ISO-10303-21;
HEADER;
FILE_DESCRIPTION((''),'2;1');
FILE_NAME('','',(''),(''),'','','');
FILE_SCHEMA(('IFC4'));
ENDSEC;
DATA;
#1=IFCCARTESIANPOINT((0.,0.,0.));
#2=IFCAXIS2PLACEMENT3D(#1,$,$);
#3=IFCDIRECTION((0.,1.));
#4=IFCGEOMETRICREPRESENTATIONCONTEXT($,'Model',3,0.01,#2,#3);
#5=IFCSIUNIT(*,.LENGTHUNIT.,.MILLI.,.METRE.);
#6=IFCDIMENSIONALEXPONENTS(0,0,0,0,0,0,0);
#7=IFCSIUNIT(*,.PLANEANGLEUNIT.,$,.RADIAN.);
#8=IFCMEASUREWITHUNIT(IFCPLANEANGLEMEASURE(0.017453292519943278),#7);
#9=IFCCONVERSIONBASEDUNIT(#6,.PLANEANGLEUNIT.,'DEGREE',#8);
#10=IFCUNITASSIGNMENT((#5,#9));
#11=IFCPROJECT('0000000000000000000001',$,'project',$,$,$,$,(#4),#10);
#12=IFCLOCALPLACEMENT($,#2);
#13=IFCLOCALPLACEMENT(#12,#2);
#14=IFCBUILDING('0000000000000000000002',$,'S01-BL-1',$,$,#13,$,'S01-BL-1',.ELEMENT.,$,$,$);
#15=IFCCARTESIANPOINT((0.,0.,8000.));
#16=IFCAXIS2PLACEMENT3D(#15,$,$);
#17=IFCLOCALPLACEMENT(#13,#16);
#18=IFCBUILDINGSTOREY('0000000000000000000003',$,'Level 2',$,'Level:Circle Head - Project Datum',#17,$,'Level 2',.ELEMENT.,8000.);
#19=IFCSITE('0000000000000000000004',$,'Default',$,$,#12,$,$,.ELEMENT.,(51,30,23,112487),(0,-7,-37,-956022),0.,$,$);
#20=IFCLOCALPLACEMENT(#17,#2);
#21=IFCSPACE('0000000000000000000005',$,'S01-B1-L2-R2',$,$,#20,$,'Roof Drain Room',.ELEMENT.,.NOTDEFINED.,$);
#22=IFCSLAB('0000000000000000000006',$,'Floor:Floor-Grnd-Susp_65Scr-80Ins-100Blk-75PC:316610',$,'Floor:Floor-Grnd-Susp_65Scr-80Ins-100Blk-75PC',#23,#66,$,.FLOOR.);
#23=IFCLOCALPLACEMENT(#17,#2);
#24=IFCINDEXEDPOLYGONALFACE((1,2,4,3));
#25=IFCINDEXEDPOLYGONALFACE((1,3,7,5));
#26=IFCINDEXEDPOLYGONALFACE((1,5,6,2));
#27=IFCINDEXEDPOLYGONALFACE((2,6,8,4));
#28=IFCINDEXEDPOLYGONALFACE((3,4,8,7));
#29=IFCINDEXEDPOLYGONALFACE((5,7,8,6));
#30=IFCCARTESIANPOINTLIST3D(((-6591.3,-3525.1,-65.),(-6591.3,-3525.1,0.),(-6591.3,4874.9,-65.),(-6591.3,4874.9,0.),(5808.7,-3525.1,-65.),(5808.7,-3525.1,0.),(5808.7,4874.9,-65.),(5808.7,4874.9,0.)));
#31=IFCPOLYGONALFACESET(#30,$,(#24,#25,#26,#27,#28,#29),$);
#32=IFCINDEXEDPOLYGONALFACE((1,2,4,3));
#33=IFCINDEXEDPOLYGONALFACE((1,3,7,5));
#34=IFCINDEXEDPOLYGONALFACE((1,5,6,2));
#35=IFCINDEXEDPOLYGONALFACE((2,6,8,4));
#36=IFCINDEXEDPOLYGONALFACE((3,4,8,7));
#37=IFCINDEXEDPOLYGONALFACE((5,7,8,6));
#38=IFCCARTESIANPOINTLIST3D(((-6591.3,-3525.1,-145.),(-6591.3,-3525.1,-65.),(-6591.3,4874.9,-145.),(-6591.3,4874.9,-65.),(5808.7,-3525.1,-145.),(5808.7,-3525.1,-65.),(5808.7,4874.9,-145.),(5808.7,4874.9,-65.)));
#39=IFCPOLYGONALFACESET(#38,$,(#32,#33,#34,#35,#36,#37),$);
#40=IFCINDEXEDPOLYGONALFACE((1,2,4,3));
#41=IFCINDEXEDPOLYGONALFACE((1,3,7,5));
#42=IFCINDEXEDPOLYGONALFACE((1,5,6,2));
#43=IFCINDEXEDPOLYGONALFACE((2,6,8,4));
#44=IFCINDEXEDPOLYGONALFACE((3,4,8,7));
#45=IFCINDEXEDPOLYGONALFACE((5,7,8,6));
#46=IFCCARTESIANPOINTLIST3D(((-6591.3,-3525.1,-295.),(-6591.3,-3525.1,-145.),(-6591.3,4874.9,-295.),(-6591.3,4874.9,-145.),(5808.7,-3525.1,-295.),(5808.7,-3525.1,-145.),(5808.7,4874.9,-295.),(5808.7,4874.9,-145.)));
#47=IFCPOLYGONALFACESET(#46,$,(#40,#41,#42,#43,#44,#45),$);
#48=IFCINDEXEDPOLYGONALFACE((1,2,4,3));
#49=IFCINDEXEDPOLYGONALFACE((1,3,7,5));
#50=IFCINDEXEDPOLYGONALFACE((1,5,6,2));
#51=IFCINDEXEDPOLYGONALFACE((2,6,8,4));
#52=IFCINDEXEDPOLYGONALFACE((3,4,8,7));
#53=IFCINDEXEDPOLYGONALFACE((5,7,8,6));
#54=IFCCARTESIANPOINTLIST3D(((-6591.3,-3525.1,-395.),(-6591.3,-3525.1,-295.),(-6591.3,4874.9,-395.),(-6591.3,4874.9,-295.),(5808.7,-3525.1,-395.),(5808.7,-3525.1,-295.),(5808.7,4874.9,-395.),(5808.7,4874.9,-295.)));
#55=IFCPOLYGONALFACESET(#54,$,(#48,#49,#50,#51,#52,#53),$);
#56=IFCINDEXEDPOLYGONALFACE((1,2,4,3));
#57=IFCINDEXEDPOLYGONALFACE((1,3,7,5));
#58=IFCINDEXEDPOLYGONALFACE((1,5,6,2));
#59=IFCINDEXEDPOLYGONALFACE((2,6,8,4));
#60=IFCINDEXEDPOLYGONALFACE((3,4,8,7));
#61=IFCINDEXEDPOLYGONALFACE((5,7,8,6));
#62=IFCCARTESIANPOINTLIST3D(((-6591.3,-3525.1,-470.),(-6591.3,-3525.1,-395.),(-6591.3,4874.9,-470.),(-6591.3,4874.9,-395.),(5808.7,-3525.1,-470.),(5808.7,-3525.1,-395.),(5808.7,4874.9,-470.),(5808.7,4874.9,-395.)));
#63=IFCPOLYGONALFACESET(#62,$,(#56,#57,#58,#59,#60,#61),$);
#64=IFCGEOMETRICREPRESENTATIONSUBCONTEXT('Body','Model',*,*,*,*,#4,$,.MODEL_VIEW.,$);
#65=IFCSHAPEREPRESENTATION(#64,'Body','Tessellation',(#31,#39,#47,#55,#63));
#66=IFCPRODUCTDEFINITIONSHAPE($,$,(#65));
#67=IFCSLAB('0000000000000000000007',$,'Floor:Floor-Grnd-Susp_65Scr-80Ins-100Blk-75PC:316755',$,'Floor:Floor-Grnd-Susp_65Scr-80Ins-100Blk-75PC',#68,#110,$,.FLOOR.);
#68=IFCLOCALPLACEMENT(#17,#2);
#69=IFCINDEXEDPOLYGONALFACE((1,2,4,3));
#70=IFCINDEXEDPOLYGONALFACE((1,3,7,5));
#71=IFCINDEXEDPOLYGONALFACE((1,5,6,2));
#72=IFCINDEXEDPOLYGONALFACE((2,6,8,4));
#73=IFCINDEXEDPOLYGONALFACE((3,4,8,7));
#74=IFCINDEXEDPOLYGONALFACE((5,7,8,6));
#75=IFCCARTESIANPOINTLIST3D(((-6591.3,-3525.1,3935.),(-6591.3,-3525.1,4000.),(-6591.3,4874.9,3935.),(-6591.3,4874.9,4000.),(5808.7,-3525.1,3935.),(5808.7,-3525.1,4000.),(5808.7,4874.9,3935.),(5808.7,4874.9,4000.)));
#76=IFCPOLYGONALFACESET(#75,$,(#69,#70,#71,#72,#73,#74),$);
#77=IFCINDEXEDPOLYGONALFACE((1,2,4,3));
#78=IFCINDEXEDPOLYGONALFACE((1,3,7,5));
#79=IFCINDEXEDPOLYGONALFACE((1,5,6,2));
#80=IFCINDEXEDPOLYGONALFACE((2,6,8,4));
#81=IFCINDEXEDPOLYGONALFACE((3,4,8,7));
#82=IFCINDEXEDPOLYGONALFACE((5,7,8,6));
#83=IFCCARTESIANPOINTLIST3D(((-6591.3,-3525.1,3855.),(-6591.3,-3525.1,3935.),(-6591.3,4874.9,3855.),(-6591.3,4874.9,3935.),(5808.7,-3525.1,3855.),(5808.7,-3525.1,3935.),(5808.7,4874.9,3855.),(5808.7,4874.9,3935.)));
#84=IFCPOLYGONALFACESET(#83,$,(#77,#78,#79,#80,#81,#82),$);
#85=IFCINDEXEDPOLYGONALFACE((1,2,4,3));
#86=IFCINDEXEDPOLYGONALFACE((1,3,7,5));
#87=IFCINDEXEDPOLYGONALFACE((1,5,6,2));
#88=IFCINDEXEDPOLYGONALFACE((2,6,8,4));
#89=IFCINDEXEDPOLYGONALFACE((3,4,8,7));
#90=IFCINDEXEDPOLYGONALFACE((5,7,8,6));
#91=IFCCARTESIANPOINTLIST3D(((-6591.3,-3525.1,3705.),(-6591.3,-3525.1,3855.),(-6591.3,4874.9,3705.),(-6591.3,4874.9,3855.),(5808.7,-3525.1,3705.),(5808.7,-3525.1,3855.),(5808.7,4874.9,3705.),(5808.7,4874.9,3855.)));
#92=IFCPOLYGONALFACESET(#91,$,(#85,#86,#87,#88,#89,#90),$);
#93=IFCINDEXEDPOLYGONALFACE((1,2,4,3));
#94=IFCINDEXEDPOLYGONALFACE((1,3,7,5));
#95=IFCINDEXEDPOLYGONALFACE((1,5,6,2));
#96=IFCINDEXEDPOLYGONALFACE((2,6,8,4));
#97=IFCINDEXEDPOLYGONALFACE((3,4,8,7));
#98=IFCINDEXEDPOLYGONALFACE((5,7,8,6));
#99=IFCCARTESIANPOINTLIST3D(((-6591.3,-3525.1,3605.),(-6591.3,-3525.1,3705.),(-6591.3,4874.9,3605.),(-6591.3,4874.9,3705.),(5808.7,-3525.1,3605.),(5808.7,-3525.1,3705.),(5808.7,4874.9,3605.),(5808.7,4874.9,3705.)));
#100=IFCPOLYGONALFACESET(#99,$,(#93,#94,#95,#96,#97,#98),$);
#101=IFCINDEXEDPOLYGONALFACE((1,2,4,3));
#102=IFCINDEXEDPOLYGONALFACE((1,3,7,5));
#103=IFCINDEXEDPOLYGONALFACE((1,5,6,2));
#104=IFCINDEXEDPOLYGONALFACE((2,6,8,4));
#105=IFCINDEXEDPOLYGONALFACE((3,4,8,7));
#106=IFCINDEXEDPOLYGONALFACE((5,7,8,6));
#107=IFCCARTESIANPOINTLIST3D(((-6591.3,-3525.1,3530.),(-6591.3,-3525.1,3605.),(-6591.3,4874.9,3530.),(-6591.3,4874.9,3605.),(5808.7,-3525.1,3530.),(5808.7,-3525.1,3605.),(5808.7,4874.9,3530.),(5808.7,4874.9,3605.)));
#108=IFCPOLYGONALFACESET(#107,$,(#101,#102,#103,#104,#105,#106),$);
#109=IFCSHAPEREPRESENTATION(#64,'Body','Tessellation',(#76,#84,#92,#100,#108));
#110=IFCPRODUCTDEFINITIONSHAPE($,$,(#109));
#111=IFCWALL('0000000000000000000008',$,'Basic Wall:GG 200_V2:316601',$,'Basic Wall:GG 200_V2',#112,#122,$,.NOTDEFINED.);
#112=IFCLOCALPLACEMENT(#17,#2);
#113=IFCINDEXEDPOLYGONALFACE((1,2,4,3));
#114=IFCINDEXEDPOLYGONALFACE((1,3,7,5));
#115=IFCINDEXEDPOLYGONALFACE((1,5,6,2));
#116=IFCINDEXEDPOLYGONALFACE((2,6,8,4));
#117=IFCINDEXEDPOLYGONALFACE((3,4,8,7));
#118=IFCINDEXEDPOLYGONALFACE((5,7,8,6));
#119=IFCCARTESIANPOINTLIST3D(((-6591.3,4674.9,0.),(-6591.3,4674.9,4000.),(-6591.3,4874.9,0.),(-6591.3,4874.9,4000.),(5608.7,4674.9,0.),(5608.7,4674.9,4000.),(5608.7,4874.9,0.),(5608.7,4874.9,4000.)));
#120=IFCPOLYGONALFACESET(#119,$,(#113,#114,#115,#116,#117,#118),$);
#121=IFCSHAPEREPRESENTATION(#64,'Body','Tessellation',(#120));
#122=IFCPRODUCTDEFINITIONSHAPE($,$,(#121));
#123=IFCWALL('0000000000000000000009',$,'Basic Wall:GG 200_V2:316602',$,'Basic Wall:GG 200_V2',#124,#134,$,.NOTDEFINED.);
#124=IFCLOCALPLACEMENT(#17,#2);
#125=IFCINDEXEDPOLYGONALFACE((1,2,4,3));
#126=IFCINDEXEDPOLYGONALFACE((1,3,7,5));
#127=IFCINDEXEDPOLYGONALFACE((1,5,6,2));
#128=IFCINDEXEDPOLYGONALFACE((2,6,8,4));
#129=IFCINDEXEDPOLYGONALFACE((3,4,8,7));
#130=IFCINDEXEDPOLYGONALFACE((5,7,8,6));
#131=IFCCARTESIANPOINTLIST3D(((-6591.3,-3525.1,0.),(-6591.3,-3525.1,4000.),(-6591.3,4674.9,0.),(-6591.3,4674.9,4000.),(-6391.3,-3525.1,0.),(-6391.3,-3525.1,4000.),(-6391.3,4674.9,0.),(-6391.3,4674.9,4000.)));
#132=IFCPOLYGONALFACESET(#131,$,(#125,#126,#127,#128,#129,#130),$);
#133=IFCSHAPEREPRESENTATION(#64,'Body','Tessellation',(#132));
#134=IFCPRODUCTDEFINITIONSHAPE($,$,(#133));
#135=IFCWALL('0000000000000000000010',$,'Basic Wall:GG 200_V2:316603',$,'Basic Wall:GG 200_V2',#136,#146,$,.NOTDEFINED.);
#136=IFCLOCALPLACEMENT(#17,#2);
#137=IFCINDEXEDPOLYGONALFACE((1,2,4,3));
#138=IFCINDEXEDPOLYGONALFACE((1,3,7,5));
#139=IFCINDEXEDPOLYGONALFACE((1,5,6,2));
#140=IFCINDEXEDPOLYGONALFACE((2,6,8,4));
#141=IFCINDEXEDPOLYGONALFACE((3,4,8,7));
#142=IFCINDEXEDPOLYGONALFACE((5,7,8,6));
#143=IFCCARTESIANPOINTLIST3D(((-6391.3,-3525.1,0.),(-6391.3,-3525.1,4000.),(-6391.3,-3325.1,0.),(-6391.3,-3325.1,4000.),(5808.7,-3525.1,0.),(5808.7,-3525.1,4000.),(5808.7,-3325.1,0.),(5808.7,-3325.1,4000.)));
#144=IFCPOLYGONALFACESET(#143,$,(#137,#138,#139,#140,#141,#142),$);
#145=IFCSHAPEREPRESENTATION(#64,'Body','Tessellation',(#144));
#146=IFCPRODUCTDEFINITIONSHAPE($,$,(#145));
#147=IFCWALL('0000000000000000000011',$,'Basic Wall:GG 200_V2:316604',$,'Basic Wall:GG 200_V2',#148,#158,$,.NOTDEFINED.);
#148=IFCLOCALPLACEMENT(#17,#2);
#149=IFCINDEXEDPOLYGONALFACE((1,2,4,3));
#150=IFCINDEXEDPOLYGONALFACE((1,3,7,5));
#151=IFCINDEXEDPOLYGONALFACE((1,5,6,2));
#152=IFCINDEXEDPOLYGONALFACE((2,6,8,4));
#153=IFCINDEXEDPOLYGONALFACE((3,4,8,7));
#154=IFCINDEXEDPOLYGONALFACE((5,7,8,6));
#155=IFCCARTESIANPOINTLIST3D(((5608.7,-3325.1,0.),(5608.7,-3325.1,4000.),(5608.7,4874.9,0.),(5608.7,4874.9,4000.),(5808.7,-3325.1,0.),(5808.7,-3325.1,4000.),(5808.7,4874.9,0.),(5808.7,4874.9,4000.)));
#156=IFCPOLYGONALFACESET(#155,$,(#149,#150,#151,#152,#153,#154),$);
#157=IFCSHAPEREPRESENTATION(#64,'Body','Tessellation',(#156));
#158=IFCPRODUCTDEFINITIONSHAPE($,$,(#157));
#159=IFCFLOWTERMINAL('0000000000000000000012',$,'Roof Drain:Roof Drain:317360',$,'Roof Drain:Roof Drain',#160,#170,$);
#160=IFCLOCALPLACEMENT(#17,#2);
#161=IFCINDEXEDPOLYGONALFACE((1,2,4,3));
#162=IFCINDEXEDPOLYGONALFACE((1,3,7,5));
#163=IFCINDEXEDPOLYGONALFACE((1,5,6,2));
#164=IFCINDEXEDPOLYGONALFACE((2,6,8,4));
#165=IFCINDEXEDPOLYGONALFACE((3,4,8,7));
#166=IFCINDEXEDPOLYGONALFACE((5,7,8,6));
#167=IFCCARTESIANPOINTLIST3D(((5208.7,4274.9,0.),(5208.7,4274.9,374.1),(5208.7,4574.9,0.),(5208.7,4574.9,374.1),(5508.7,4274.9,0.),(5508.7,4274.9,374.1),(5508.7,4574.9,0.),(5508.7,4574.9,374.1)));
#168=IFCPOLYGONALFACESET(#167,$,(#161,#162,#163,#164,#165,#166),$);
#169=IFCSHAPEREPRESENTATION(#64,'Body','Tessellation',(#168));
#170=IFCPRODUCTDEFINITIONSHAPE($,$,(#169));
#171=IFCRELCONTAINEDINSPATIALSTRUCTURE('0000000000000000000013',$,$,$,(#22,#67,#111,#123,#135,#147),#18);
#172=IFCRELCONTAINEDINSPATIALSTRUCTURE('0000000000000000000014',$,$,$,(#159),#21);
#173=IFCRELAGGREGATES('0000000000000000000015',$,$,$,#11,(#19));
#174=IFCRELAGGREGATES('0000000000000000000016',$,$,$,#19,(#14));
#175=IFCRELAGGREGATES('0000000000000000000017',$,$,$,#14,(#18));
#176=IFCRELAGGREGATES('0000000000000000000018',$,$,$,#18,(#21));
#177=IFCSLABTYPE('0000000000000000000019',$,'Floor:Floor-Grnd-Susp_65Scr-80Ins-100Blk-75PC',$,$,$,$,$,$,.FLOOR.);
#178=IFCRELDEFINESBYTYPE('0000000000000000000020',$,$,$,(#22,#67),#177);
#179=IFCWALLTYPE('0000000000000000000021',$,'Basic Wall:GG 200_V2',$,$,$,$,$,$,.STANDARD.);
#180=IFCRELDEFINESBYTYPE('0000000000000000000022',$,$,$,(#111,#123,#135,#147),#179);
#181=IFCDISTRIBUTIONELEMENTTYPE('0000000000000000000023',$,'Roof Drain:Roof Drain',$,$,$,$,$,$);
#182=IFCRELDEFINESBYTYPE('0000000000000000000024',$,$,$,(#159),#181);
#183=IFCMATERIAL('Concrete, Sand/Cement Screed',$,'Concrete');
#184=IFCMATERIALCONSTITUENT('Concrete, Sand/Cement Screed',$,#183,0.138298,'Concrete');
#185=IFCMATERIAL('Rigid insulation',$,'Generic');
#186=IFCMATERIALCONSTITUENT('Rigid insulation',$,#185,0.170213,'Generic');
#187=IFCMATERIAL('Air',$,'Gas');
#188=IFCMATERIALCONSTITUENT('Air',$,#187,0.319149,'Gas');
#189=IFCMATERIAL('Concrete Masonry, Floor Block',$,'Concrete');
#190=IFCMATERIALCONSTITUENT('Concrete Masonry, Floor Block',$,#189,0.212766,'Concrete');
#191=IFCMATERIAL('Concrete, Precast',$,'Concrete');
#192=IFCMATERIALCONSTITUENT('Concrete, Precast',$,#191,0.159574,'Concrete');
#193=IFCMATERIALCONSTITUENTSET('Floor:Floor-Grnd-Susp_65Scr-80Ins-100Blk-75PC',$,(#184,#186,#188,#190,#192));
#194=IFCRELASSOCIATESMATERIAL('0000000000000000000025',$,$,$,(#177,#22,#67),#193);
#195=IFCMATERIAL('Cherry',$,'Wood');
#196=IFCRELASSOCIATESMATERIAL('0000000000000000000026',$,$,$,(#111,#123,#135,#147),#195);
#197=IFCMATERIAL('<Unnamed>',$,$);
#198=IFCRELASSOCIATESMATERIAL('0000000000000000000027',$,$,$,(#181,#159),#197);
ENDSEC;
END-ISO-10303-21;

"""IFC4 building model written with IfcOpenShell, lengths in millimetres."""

from ifc_helpers import new_model, entity, si_unit, converted_unit, direction, frame, origin, place, context, subcontext, project, spatial, indexed_curve, outline, extrude, source, transform, mapped, material, constituent, constituent_set, type_object, type_shapes, element, save


model = new_model("IFC4")

# Units and contexts
model_context = context("Model", 3, precision=0.01, world=origin(), true_north=direction((0.0, 1.0)))
body_context = subcontext(model_context, "Body", "Model", "MODEL_VIEW")
ifc_project = project(units=[si_unit("LENGTHUNIT", "METRE", prefix="MILLI"), converted_unit("PLANEANGLEUNIT", "DEGREE", entity("IfcPlaneAngleMeasure", 0.017453292519943278), si_unit("PLANEANGLEUNIT", "RADIAN"), dimensions=[0, 0, 0, 0, 0, 0, 0])], contexts=[model_context])

# Site, building, storey
site_placement = place(None, origin())
site = spatial("IfcSite", under=ifc_project, at=site_placement, Name="Default", CompositionType="ELEMENT", RefLatitude=(51, 30, 23, 112487), RefLongitude=(0, -7, -37, -956022), RefElevation=0.0)
building_placement = place(site_placement, origin())
building = spatial("IfcBuilding", under=site, at=building_placement, Name="S01-BL-1", LongName="S01-BL-1", CompositionType="ELEMENT")
storey_placement = place(building_placement, frame((0.0, 0.0, 8000.0)))
storey = spatial("IfcBuildingStorey", under=building, at=storey_placement, Name="Level 2", ObjectType="Level:Circle Head - Project Datum", LongName="Level 2", CompositionType="ELEMENT", Elevation=8000.0)

# Slabs
ifc_material_1 = material(Name="Concrete, Sand/Cement Screed", Category="Concrete")
ifc_constituent_1 = constituent(ifc_material_1, Name="Concrete, Sand/Cement Screed", Category="Concrete", fraction=0.138298)
ifc_material_2 = material(Name="Rigid insulation", Category="Generic")
ifc_constituent_2 = constituent(ifc_material_2, Name="Rigid insulation", Category="Generic", fraction=0.170213)
ifc_material_3 = material(Name="Air", Category="Gas")
ifc_constituent_3 = constituent(ifc_material_3, Name="Air", Category="Gas", fraction=0.319149)
ifc_material_4 = material(Name="Concrete Masonry, Floor Block", Category="Concrete")
ifc_constituent_4 = constituent(ifc_material_4, Name="Concrete Masonry, Floor Block", Category="Concrete", fraction=0.212766)
ifc_material_5 = material(Name="Concrete, Precast", Category="Concrete")
ifc_constituent_5 = constituent(ifc_material_5, Name="Concrete, Precast", Category="Concrete", fraction=0.159574)
ifc_constituent_set = constituent_set(constituents=[ifc_constituent_1, ifc_constituent_2, ifc_constituent_3, ifc_constituent_4, ifc_constituent_5], Name="Floor:Floor-Grnd-Susp_65Scr-80Ins-100Blk-75PC")
slab_type = type_object("IfcSlabType", Name="Floor:Floor-Grnd-Susp_65Scr-80Ins-100Blk-75PC", PredefinedType="FLOOR", material=ifc_constituent_set)
slab_1_placement = place(storey_placement, origin())
element("IfcSlab", 1, at=slab_1_placement, inside=storey, type_object=slab_type, material=ifc_constituent_set, Name="Floor:Floor-Grnd-Susp_65Scr-80Ins-100Blk-75PC:316610", ObjectType="Floor:Floor-Grnd-Susp_65Scr-80Ins-100Blk-75PC", PredefinedType="FLOOR", context=body_context, shape_type="SweptSolid", body=[
    extrude(outline(indexed_curve([(-6200.0, -4200.0), (6200.0, -4200.0), (6200.0, 4200.0), (-6200.0, 4200.0), (-6200.0, -4200.0)], self_intersect=False)), frame((-391.3, 674.9, -65.0), z_axis=(0.0, 0.0, 1.0), x_axis=(-1.0, 0.0, 0.0)), (0.0, 0.0, 1.0), 65.0),
    extrude(outline(indexed_curve([(-6200.0, -4200.0), (6200.0, -4200.0), (6200.0, 4200.0), (-6200.0, 4200.0), (-6200.0, -4200.0)], self_intersect=False)), frame((-391.3, 674.9, -145.0), z_axis=(0.0, 0.0, 1.0), x_axis=(-1.0, 0.0, 0.0)), (0.0, 0.0, 1.0), 80.0),
    extrude(outline(indexed_curve([(-6200.0, -4200.0), (6200.0, -4200.0), (6200.0, 4200.0), (-6200.0, 4200.0), (-6200.0, -4200.0)], self_intersect=False)), frame((-391.3, 674.9, -295.0), z_axis=(0.0, 0.0, 1.0), x_axis=(-1.0, 0.0, 0.0)), (0.0, 0.0, 1.0), 150.0),
    extrude(outline(indexed_curve([(-6200.0, -4200.0), (6200.0, -4200.0), (6200.0, 4200.0), (-6200.0, 4200.0), (-6200.0, -4200.0)], self_intersect=False)), frame((-391.3, 674.9, -395.0), z_axis=(0.0, 0.0, 1.0), x_axis=(-1.0, 0.0, 0.0)), (0.0, 0.0, 1.0), 100.0),
    extrude(outline(indexed_curve([(-6200.0, -4200.0), (6200.0, -4200.0), (6200.0, 4200.0), (-6200.0, 4200.0), (-6200.0, -4200.0)], self_intersect=False)), frame((-391.3, 674.9, -470.0), z_axis=(0.0, 0.0, 1.0), x_axis=(-1.0, 0.0, 0.0)), (0.0, 0.0, 1.0), 75.0),
])
slab_2_placement = place(storey_placement, origin())
element("IfcSlab", 2, at=slab_2_placement, inside=storey, type_object=slab_type, material=ifc_constituent_set, Name="Floor:Floor-Grnd-Susp_65Scr-80Ins-100Blk-75PC:316755", ObjectType="Floor:Floor-Grnd-Susp_65Scr-80Ins-100Blk-75PC", PredefinedType="FLOOR", context=body_context, shape_type="SweptSolid", body=[
    extrude(outline(indexed_curve([(-6200.0, -4200.0), (6200.0, -4200.0), (6200.0, 4200.0), (-6200.0, 4200.0), (-6200.0, -4200.0)], self_intersect=False)), frame((-391.3, 674.9, 3935.0), z_axis=(0.0, 0.0, 1.0), x_axis=(-1.0, 0.0, 0.0)), (0.0, 0.0, 1.0), 65.0),
    extrude(outline(indexed_curve([(-6200.0, -4200.0), (6200.0, -4200.0), (6200.0, 4200.0), (-6200.0, 4200.0), (-6200.0, -4200.0)], self_intersect=False)), frame((-391.3, 674.9, 3855.0), z_axis=(0.0, 0.0, 1.0), x_axis=(-1.0, 0.0, 0.0)), (0.0, 0.0, 1.0), 80.0),
    extrude(outline(indexed_curve([(-6200.0, -4200.0), (6200.0, -4200.0), (6200.0, 4200.0), (-6200.0, 4200.0), (-6200.0, -4200.0)], self_intersect=False)), frame((-391.3, 674.9, 3705.0), z_axis=(0.0, 0.0, 1.0), x_axis=(-1.0, 0.0, 0.0)), (0.0, 0.0, 1.0), 150.0),
    extrude(outline(indexed_curve([(-6200.0, -4200.0), (6200.0, -4200.0), (6200.0, 4200.0), (-6200.0, 4200.0), (-6200.0, -4200.0)], self_intersect=False)), frame((-391.3, 674.9, 3605.0), z_axis=(0.0, 0.0, 1.0), x_axis=(-1.0, 0.0, 0.0)), (0.0, 0.0, 1.0), 100.0),
    extrude(outline(indexed_curve([(-6200.0, -4200.0), (6200.0, -4200.0), (6200.0, 4200.0), (-6200.0, 4200.0), (-6200.0, -4200.0)], self_intersect=False)), frame((-391.3, 674.9, 3530.0), z_axis=(0.0, 0.0, 1.0), x_axis=(-1.0, 0.0, 0.0)), (0.0, 0.0, 1.0), 75.0),
])

# Walls
ifc_material_6 = material(Name="Cherry", Category="Wood")
wall_type = type_object("IfcWallType", Name="Basic Wall:GG 200_V2", PredefinedType="STANDARD")
wall_1_placement = place(storey_placement, frame((-6591.3, 4774.9, 0.0)))
element("IfcWall", 3, at=wall_1_placement, inside=storey, type_object=wall_type, material=ifc_material_6, Name="Basic Wall:GG 200_V2:316601", ObjectType="Basic Wall:GG 200_V2", PredefinedType="NOTDEFINED", context=body_context, shape_type="SweptSolid", body=[
    extrude(outline(indexed_curve([(12200.0, 100.0), (0.0, 100.0), (0.0, -100.0), (12200.0, -100.0), (12200.0, 100.0)], self_intersect=False)), origin(), (0.0, 0.0, 1.0), 4000.0),
])
wall_2_placement = place(storey_placement, frame((-6491.3, -3525.1, 0.0), z_axis=(0.0, 0.0, 1.0), x_axis=(0.0, 1.0, 0.0)))
element("IfcWall", 4, at=wall_2_placement, inside=storey, type_object=wall_type, material=ifc_material_6, Name="Basic Wall:GG 200_V2:316602", ObjectType="Basic Wall:GG 200_V2", PredefinedType="NOTDEFINED", context=body_context, shape_type="SweptSolid", body=[
    extrude(outline(indexed_curve([(8200.0, 100.0), (0.0, 100.0), (0.0, -100.0), (8200.0, -100.0), (8200.0, 100.0)], self_intersect=False)), origin(), (0.0, 0.0, 1.0), 4000.0),
])
wall_3_placement = place(storey_placement, frame((5808.7, -3425.1, 0.0), z_axis=(0.0, 0.0, 1.0), x_axis=(-1.0, 0.0, 0.0)))
element("IfcWall", 5, at=wall_3_placement, inside=storey, type_object=wall_type, material=ifc_material_6, Name="Basic Wall:GG 200_V2:316603", ObjectType="Basic Wall:GG 200_V2", PredefinedType="NOTDEFINED", context=body_context, shape_type="SweptSolid", body=[
    extrude(outline(indexed_curve([(12200.0, 100.0), (0.0, 100.0), (0.0, -100.0), (12200.0, -100.0), (12200.0, 100.0)], self_intersect=False)), origin(), (0.0, 0.0, 1.0), 4000.0),
])
wall_4_placement = place(storey_placement, frame((5708.7, 4874.9, 0.0), z_axis=(0.0, 0.0, 1.0), x_axis=(0.0, -1.0, 0.0)))
element("IfcWall", 6, at=wall_4_placement, inside=storey, type_object=wall_type, material=ifc_material_6, Name="Basic Wall:GG 200_V2:316604", ObjectType="Basic Wall:GG 200_V2", PredefinedType="NOTDEFINED", context=body_context, shape_type="SweptSolid", body=[
    extrude(outline(indexed_curve([(8200.0, 100.0), (0.0, 100.0), (0.0, -100.0), (8200.0, -100.0), (8200.0, 100.0)], self_intersect=False)), origin(), (0.0, 0.0, 1.0), 4000.0),
])

# Shared definitions
space_1_placement = place(storey_placement, origin())
space_1 = spatial("IfcSpace", under=storey, at=space_1_placement, Name="S01-B1-L2-R2", LongName="Roof Drain Room", CompositionType="ELEMENT", PredefinedType="NOTDEFINED")

# Flow terminal
ifc_material_7 = material(Name="<Unnamed>")
distribution_element_type = type_object("IfcDistributionElementType", Name="Roof Drain:Roof Drain", material=ifc_material_7)
shared_shape_1 = source(origin(), body_context, "Body", "SweptSolid", [
    extrude(outline(indexed_curve([(-150.0, -150.0), (150.0, -150.0), (150.0, 150.0), (-150.0, 150.0), (-150.0, -150.0)], self_intersect=False)), frame((5358.7, 4424.9, 8000.0), z_axis=(0.0, 0.0, 1.0), x_axis=(-1.0, 0.0, 0.0)), (0.0, 0.0, 1.0), 374.1),
])
type_shapes(distribution_element_type, [shared_shape_1])
flow_terminal_placement = place(space_1_placement, frame((0.0, 0.0, -8000.0)))
element("IfcFlowTerminal", 7, at=flow_terminal_placement, inside=space_1, type_object=distribution_element_type, material=ifc_material_7, Name="Roof Drain:Roof Drain:317360", ObjectType="Roof Drain:Roof Drain", context=body_context, shape_type="MappedRepresentation", body=[
    mapped(shared_shape_1, transform((0.0, 0.0, 0.0), scale=1.0)),
])

save(model, "model.ifc")
